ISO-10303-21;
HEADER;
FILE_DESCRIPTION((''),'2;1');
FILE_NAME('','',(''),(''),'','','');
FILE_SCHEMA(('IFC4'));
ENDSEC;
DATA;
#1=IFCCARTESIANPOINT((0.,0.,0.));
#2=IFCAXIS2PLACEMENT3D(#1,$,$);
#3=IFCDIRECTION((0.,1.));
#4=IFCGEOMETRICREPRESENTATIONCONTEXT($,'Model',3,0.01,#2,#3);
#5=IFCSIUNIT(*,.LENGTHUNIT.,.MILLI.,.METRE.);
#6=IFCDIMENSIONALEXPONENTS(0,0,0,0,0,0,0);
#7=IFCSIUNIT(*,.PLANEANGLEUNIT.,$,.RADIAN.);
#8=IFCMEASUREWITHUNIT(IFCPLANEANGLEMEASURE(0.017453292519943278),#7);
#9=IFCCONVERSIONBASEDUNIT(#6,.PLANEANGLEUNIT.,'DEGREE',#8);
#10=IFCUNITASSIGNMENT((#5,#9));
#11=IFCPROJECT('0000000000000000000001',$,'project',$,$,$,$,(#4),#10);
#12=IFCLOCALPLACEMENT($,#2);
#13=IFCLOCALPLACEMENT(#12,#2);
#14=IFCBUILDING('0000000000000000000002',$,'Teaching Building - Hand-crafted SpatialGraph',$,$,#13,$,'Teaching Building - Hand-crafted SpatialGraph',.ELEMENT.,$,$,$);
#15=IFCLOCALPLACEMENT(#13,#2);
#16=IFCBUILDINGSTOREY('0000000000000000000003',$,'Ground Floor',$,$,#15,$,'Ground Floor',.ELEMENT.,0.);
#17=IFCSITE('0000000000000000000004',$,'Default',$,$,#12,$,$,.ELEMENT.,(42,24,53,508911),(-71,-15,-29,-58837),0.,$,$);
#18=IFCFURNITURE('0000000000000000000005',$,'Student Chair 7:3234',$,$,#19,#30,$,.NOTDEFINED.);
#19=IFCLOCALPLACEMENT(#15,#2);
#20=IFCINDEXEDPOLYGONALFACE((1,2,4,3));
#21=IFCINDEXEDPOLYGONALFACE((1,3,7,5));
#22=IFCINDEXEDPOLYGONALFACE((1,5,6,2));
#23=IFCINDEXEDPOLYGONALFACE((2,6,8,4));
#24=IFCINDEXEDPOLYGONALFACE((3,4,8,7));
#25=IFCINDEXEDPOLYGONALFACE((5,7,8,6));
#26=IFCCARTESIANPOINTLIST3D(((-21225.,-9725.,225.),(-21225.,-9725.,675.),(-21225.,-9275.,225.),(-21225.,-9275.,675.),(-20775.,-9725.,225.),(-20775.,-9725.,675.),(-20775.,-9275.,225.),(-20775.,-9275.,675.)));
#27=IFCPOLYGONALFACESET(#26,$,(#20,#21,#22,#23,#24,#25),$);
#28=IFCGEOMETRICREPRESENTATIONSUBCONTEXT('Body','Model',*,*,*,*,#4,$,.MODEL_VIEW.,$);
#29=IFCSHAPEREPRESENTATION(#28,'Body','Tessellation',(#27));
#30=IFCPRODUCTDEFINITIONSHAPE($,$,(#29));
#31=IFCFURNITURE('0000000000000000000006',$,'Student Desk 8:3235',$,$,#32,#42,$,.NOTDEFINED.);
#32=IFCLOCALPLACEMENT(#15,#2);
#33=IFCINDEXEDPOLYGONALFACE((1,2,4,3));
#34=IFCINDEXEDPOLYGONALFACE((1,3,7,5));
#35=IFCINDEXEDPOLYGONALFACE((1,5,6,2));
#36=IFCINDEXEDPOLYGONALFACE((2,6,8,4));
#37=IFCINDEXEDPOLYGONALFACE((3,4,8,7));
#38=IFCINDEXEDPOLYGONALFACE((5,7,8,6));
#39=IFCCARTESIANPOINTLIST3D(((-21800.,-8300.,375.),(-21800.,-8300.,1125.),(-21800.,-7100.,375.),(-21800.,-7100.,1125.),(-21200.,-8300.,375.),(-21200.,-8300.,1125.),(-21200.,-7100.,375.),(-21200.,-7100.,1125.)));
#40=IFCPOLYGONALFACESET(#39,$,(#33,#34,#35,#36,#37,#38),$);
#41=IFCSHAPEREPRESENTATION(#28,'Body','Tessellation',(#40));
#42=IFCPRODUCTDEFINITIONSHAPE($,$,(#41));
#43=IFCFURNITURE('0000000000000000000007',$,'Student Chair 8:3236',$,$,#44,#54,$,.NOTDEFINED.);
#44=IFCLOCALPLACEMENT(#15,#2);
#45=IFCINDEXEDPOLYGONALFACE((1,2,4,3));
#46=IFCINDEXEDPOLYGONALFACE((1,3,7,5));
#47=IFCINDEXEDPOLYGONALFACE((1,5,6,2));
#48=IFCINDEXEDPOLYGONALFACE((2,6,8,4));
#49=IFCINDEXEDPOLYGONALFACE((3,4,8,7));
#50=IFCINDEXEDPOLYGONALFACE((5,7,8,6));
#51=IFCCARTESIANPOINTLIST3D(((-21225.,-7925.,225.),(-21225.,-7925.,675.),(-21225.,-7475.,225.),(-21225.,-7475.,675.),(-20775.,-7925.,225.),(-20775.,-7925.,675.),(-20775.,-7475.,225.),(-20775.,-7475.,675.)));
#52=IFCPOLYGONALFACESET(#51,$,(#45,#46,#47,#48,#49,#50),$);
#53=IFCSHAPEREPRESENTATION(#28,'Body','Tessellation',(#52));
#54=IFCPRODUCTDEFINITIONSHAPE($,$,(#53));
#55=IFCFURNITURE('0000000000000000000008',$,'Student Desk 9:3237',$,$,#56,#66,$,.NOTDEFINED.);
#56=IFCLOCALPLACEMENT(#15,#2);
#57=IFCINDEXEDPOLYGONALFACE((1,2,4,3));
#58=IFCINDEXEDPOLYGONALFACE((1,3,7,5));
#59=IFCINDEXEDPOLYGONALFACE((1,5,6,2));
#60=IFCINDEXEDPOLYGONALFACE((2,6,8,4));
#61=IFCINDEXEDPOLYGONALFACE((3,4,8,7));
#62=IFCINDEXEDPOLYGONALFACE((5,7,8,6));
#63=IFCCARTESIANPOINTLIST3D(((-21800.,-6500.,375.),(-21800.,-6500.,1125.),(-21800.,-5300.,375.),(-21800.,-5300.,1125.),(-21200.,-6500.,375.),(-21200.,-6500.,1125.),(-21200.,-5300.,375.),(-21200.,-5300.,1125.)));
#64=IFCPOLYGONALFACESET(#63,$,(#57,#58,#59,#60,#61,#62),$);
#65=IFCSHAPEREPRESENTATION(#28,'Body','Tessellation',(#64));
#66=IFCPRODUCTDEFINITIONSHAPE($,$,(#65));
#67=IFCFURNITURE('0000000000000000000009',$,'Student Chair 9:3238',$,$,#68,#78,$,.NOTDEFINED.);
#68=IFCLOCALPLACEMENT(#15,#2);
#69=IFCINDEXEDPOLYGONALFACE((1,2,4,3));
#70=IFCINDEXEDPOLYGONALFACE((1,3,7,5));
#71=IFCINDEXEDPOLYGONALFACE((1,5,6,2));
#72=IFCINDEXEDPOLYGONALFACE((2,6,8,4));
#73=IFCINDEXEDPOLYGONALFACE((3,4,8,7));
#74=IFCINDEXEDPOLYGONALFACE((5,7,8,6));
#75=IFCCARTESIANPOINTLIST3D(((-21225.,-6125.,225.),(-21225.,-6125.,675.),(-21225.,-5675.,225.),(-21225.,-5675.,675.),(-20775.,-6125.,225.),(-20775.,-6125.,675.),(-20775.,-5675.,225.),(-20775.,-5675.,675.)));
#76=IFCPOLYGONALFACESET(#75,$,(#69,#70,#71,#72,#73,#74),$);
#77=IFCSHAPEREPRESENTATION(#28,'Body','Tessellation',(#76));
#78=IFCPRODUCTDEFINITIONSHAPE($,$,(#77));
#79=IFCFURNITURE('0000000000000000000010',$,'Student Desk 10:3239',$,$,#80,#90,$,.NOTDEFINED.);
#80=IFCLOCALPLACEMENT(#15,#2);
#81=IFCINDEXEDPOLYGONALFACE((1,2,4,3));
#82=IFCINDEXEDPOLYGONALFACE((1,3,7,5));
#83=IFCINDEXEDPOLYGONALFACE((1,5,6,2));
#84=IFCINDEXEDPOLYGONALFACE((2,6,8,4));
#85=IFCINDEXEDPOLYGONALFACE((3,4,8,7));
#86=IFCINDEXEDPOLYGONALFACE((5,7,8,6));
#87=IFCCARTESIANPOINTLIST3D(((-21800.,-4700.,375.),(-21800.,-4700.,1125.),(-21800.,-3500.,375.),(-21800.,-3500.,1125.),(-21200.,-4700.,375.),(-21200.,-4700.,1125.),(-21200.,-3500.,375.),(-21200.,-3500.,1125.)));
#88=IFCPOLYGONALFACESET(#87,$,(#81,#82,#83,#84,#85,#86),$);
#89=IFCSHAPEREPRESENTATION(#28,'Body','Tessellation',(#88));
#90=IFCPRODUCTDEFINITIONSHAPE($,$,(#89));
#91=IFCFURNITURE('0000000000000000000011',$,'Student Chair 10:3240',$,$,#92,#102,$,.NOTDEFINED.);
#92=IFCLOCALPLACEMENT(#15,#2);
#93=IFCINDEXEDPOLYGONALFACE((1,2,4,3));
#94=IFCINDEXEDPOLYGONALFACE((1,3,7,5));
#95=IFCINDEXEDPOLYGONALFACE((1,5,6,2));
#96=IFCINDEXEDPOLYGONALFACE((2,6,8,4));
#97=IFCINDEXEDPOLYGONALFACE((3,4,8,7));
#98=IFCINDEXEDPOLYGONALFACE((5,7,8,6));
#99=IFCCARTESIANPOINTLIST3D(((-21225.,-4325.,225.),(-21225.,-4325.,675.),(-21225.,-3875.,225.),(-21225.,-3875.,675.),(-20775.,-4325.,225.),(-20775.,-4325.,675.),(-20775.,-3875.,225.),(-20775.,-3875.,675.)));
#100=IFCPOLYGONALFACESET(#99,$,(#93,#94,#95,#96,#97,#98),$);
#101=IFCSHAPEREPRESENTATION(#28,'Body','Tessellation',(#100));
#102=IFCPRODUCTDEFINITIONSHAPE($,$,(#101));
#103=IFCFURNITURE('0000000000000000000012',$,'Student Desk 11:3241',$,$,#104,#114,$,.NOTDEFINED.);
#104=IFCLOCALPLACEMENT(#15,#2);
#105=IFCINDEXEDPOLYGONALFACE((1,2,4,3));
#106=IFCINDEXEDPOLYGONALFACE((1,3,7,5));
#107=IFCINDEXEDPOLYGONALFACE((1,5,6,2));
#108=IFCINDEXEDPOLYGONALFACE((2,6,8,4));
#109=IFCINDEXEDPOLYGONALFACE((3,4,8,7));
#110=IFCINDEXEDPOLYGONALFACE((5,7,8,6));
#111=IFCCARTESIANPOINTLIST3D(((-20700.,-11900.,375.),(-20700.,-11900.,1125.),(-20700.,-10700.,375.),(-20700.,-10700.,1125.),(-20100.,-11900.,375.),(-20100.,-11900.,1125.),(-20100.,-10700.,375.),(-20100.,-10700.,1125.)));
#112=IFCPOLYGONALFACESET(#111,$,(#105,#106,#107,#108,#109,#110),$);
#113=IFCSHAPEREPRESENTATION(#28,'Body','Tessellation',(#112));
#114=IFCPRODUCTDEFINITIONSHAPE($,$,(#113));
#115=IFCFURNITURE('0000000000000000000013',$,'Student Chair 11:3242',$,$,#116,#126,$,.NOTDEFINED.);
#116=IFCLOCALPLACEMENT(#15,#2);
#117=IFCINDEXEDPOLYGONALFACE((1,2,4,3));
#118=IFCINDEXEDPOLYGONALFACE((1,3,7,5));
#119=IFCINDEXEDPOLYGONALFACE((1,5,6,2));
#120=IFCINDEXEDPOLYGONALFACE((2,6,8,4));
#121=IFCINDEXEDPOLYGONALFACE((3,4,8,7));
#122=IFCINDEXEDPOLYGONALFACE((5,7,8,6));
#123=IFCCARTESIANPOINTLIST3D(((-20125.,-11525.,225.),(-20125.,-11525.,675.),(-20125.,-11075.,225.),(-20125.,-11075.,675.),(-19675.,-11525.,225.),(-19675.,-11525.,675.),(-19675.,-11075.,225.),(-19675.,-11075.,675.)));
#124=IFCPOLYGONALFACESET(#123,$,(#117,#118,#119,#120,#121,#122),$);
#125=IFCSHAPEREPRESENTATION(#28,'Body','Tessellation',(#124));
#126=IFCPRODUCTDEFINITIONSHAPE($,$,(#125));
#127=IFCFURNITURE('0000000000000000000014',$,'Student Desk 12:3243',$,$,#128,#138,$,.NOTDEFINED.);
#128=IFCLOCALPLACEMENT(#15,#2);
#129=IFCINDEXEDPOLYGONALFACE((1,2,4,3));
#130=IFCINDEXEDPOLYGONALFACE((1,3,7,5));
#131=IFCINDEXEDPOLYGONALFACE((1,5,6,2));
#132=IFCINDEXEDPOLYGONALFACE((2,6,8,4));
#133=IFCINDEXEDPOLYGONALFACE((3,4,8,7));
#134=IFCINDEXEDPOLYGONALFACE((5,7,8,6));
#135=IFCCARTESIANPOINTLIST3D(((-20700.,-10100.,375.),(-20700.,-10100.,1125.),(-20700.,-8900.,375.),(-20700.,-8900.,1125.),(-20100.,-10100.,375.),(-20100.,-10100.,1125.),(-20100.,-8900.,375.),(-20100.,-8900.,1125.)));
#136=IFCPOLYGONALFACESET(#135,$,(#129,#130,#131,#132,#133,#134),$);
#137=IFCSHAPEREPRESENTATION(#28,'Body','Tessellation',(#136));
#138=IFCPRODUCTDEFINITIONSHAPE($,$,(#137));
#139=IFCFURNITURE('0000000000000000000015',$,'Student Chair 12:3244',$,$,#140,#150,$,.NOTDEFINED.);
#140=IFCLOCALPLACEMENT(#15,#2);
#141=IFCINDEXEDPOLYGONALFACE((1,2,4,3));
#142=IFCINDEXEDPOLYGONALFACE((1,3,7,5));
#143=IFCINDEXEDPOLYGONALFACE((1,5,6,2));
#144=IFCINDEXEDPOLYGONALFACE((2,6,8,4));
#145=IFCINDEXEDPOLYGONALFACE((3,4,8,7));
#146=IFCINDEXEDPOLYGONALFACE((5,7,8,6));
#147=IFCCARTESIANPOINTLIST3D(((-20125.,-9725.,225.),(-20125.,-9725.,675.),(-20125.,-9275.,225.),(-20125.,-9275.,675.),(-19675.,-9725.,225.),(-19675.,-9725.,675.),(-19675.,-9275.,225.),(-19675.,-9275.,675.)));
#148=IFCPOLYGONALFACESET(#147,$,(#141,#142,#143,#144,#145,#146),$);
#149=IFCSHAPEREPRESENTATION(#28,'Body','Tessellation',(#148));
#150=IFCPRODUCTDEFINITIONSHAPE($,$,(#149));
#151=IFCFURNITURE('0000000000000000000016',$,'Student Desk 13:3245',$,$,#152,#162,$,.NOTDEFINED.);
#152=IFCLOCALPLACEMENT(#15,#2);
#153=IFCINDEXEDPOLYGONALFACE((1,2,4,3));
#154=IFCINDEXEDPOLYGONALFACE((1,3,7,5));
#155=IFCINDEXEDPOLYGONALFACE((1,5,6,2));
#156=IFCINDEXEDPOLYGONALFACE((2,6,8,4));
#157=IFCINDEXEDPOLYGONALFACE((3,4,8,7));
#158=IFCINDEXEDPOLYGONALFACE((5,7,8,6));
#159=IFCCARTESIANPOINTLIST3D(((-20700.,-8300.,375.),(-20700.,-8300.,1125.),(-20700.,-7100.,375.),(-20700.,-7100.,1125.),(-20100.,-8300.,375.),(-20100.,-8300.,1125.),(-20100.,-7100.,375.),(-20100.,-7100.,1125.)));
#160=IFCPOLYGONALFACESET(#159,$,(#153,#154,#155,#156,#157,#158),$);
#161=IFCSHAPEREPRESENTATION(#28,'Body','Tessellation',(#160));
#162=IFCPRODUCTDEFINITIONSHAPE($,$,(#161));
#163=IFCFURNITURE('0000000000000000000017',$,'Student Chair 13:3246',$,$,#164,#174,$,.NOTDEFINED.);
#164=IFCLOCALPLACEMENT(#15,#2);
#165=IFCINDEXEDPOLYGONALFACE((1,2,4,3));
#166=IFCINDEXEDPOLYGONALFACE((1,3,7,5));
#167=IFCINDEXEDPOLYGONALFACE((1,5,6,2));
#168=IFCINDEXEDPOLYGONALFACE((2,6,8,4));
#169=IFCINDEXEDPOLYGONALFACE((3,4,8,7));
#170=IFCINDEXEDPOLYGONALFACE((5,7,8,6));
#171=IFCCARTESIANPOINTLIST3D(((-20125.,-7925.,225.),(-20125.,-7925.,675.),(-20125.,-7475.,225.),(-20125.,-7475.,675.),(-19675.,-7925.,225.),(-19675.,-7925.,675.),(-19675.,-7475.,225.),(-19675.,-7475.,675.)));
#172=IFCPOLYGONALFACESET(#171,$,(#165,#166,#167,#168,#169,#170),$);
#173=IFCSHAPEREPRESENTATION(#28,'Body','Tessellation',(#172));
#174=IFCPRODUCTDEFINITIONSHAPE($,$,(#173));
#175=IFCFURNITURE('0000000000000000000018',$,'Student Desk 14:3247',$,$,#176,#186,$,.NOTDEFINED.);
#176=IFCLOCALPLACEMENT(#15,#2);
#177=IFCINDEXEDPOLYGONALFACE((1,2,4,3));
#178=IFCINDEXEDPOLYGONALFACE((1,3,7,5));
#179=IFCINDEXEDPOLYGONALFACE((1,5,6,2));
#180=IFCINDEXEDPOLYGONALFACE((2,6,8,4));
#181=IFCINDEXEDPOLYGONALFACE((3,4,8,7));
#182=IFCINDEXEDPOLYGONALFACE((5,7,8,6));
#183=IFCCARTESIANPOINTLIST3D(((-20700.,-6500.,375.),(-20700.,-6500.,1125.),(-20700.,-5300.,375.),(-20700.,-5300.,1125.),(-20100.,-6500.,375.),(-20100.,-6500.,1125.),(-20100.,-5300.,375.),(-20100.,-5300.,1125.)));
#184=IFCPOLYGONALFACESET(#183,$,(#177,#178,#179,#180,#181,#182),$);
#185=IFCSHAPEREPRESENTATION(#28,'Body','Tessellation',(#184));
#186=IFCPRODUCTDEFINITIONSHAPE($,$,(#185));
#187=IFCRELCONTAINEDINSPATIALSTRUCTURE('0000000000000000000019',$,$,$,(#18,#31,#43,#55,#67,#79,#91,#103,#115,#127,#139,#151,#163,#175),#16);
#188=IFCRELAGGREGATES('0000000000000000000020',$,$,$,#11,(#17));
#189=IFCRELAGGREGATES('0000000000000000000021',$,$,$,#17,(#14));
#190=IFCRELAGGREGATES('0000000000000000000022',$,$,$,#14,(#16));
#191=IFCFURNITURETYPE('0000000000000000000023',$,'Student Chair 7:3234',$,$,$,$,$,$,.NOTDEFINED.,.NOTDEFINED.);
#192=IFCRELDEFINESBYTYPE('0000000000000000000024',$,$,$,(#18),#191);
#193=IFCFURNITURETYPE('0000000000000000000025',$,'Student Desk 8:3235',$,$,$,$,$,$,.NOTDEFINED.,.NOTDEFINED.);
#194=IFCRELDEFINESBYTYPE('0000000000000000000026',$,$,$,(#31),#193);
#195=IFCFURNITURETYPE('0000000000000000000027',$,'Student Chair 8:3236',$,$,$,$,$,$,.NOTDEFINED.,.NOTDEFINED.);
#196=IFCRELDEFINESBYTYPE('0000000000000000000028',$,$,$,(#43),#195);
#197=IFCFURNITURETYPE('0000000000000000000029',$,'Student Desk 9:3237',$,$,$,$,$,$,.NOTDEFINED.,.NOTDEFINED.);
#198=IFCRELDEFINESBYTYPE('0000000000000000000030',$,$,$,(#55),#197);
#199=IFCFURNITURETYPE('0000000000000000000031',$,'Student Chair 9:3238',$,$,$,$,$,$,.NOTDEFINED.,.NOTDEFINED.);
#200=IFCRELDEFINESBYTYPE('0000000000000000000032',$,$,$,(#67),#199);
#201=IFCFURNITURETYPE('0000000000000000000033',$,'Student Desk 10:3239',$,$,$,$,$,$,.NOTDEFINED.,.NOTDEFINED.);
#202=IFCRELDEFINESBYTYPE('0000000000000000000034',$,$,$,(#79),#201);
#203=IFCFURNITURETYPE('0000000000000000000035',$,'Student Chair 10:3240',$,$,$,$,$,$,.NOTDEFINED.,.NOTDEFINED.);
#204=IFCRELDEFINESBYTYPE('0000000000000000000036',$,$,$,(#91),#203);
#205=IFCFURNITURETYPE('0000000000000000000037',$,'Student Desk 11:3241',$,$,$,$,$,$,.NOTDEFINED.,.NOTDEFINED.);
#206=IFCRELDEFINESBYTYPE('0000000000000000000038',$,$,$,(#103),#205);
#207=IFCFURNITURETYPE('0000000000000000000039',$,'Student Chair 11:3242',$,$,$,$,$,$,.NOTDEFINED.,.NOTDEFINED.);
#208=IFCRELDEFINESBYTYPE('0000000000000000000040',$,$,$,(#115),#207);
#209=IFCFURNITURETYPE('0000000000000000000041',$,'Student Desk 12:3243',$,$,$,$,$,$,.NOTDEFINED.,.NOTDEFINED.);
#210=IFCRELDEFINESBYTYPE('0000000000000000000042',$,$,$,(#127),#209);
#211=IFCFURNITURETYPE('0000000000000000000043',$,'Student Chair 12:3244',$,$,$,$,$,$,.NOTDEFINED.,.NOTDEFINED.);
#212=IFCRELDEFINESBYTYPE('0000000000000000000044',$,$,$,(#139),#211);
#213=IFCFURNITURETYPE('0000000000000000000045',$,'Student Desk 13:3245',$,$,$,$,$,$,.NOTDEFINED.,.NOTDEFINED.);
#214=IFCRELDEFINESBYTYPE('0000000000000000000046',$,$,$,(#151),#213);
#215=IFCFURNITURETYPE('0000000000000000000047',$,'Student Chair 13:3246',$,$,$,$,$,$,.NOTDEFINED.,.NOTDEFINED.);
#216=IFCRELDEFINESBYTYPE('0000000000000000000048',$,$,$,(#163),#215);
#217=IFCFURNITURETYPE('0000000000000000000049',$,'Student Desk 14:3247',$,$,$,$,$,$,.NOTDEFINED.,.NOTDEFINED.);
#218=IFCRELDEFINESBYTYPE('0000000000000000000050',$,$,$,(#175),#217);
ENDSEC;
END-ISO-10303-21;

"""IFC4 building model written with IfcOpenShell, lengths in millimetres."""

from ifc_helpers import new_model, entity, si_unit, converted_unit, direction, frame, frame_2d, origin, origin_2d_with_axis, place, context, subcontext, project, spatial, rectangle, extrude, type_object, element, save


model = new_model("IFC4")

# Units and contexts
model_context = context("Model", 3, precision=0.01, world=origin(), true_north=direction((0.0, 1.0)))
body_context = subcontext(model_context, "Body", "Model", "MODEL_VIEW")
ifc_project = project(units=[si_unit("LENGTHUNIT", "METRE", prefix="MILLI"), converted_unit("PLANEANGLEUNIT", "DEGREE", entity("IfcPlaneAngleMeasure", 0.017453292519943278), si_unit("PLANEANGLEUNIT", "RADIAN"), dimensions=[0, 0, 0, 0, 0, 0, 0])], contexts=[model_context])

# Site, building, storey
site_placement = place(None, origin())
site = spatial("IfcSite", under=ifc_project, at=site_placement, Name="Default", CompositionType="ELEMENT", RefLatitude=(42, 24, 53, 508911), RefLongitude=(-71, -15, -29, -58837), RefElevation=0.0)
building_placement = place(site_placement, origin())
building = spatial("IfcBuilding", under=site, at=building_placement, Name="Teaching Building - Hand-crafted SpatialGraph", LongName="Teaching Building - Hand-crafted SpatialGraph", CompositionType="ELEMENT")
storey_placement = place(building_placement, origin())
storey = spatial("IfcBuildingStorey", under=building, at=storey_placement, Name="Ground Floor", LongName="Ground Floor", CompositionType="ELEMENT", Elevation=0.0)

# Furniture
furniture_type_1 = type_object("IfcFurnitureType", Name="Student Chair 7:3234", PredefinedType="NOTDEFINED")
furniture_1_placement = place(storey_placement, origin())
element("IfcFurniture", 1, at=furniture_1_placement, inside=storey, type_object=furniture_type_1, Name="Student Chair 7:3234", PredefinedType="NOTDEFINED", context=body_context, shape_type="SweptSolid", body=[
    extrude(rectangle(XDim=450.0, YDim=450.0, at=origin_2d_with_axis()), frame((-21000.0, -9500.0, 225.0)), (0.0, 0.0, 1.0), 450.0),
])
furniture_type_2 = type_object("IfcFurnitureType", Name="Student Desk 8:3235", PredefinedType="NOTDEFINED")
furniture_2_placement = place(storey_placement, origin())
element("IfcFurniture", 2, at=furniture_2_placement, inside=storey, type_object=furniture_type_2, Name="Student Desk 8:3235", PredefinedType="NOTDEFINED", context=body_context, shape_type="SweptSolid", body=[
    extrude(rectangle(XDim=1200.0, YDim=600.0, at=origin_2d_with_axis()), frame((-21500.0, -7700.0, 375.0), z_axis=(0.0, 0.0, 1.0), x_axis=(0.0, 1.0, 0.0)), (0.0, 0.0, 1.0), 750.0),
])
furniture_type_3 = type_object("IfcFurnitureType", Name="Student Chair 8:3236", PredefinedType="NOTDEFINED")
furniture_3_placement = place(storey_placement, origin())
element("IfcFurniture", 3, at=furniture_3_placement, inside=storey, type_object=furniture_type_3, Name="Student Chair 8:3236", PredefinedType="NOTDEFINED", context=body_context, shape_type="SweptSolid", body=[
    extrude(rectangle(XDim=450.0, YDim=450.0, at=frame_2d((0.0, 0.0), x_axis=(1.0, 0.0))), frame((-21000.0, -7700.0, 225.0)), (0.0, 0.0, 1.0), 450.0),
])
furniture_type_4 = type_object("IfcFurnitureType", Name="Student Desk 9:3237", PredefinedType="NOTDEFINED")
furniture_4_placement = place(storey_placement, origin())
element("IfcFurniture", 4, at=furniture_4_placement, inside=storey, type_object=furniture_type_4, Name="Student Desk 9:3237", PredefinedType="NOTDEFINED", context=body_context, shape_type="SweptSolid", body=[
    extrude(rectangle(XDim=1200.0, YDim=600.0, at=origin_2d_with_axis()), frame((-21500.0, -5900.0, 375.0), z_axis=(0.0, 0.0, 1.0), x_axis=(0.0, 1.0, 0.0)), (0.0, 0.0, 1.0), 750.0),
])
furniture_type_5 = type_object("IfcFurnitureType", Name="Student Chair 9:3238", PredefinedType="NOTDEFINED")
furniture_5_placement = place(storey_placement, origin())
element("IfcFurniture", 5, at=furniture_5_placement, inside=storey, type_object=furniture_type_5, Name="Student Chair 9:3238", PredefinedType="NOTDEFINED", context=body_context, shape_type="SweptSolid", body=[
    extrude(rectangle(XDim=450.0, YDim=450.0, at=origin_2d_with_axis()), frame((-21000.0, -5900.0, 225.0)), (0.0, 0.0, 1.0), 450.0),
])
furniture_type_6 = type_object("IfcFurnitureType", Name="Student Desk 10:3239", PredefinedType="NOTDEFINED")
furniture_6_placement = place(storey_placement, origin())
element("IfcFurniture", 6, at=furniture_6_placement, inside=storey, type_object=furniture_type_6, Name="Student Desk 10:3239", PredefinedType="NOTDEFINED", context=body_context, shape_type="SweptSolid", body=[
    extrude(rectangle(XDim=1200.0, YDim=600.0, at=origin_2d_with_axis()), frame((-21500.0, -4100.0, 375.0), z_axis=(0.0, 0.0, 1.0), x_axis=(0.0, 1.0, 0.0)), (0.0, 0.0, 1.0), 750.0),
])
furniture_type_7 = type_object("IfcFurnitureType", Name="Student Chair 10:3240", PredefinedType="NOTDEFINED")
furniture_7_placement = place(storey_placement, origin())
element("IfcFurniture", 7, at=furniture_7_placement, inside=storey, type_object=furniture_type_7, Name="Student Chair 10:3240", PredefinedType="NOTDEFINED", context=body_context, shape_type="SweptSolid", body=[
    extrude(rectangle(XDim=450.0, YDim=450.0, at=origin_2d_with_axis()), frame((-21000.0, -4100.0, 225.0)), (0.0, 0.0, 1.0), 450.0),
])
furniture_type_8 = type_object("IfcFurnitureType", Name="Student Desk 11:3241", PredefinedType="NOTDEFINED")
furniture_8_placement = place(storey_placement, origin())
element("IfcFurniture", 8, at=furniture_8_placement, inside=storey, type_object=furniture_type_8, Name="Student Desk 11:3241", PredefinedType="NOTDEFINED", context=body_context, shape_type="SweptSolid", body=[
    extrude(rectangle(XDim=1200.0, YDim=600.0, at=origin_2d_with_axis()), frame((-20400.0, -11300.0, 375.0), z_axis=(0.0, 0.0, 1.0), x_axis=(0.0, 1.0, 0.0)), (0.0, 0.0, 1.0), 750.0),
])
furniture_type_9 = type_object("IfcFurnitureType", Name="Student Chair 11:3242", PredefinedType="NOTDEFINED")
furniture_9_placement = place(storey_placement, origin())
element("IfcFurniture", 9, at=furniture_9_placement, inside=storey, type_object=furniture_type_9, Name="Student Chair 11:3242", PredefinedType="NOTDEFINED", context=body_context, shape_type="SweptSolid", body=[
    extrude(rectangle(XDim=450.0, YDim=450.0, at=origin_2d_with_axis()), frame((-19900.0, -11300.0, 225.0)), (0.0, 0.0, 1.0), 450.0),
])
furniture_type_10 = type_object("IfcFurnitureType", Name="Student Desk 12:3243", PredefinedType="NOTDEFINED")
furniture_10_placement = place(storey_placement, origin())
element("IfcFurniture", 10, at=furniture_10_placement, inside=storey, type_object=furniture_type_10, Name="Student Desk 12:3243", PredefinedType="NOTDEFINED", context=body_context, shape_type="SweptSolid", body=[
    extrude(rectangle(XDim=1200.0, YDim=600.0, at=origin_2d_with_axis()), frame((-20400.0, -9500.0, 375.0), z_axis=(0.0, 0.0, 1.0), x_axis=(0.0, 1.0, 0.0)), (0.0, 0.0, 1.0), 750.0),
])
furniture_type_11 = type_object("IfcFurnitureType", Name="Student Chair 12:3244", PredefinedType="NOTDEFINED")
furniture_11_placement = place(storey_placement, origin())
element("IfcFurniture", 11, at=furniture_11_placement, inside=storey, type_object=furniture_type_11, Name="Student Chair 12:3244", PredefinedType="NOTDEFINED", context=body_context, shape_type="SweptSolid", body=[
    extrude(rectangle(XDim=450.0, YDim=450.0, at=origin_2d_with_axis()), frame((-19900.0, -9500.0, 225.0)), (0.0, 0.0, 1.0), 450.0),
])
furniture_type_12 = type_object("IfcFurnitureType", Name="Student Desk 13:3245", PredefinedType="NOTDEFINED")
furniture_12_placement = place(storey_placement, origin())
element("IfcFurniture", 12, at=furniture_12_placement, inside=storey, type_object=furniture_type_12, Name="Student Desk 13:3245", PredefinedType="NOTDEFINED", context=body_context, shape_type="SweptSolid", body=[
    extrude(rectangle(XDim=1200.0, YDim=600.0, at=origin_2d_with_axis()), frame((-20400.0, -7700.0, 375.0), z_axis=(0.0, 0.0, 1.0), x_axis=(0.0, 1.0, 0.0)), (0.0, 0.0, 1.0), 750.0),
])
furniture_type_13 = type_object("IfcFurnitureType", Name="Student Chair 13:3246", PredefinedType="NOTDEFINED")
furniture_13_placement = place(storey_placement, origin())
element("IfcFurniture", 13, at=furniture_13_placement, inside=storey, type_object=furniture_type_13, Name="Student Chair 13:3246", PredefinedType="NOTDEFINED", context=body_context, shape_type="SweptSolid", body=[
    extrude(rectangle(XDim=450.0, YDim=450.0, at=frame_2d((0.0, 0.0), x_axis=(1.0, 0.0))), frame((-19900.0, -7700.0, 225.0)), (0.0, 0.0, 1.0), 450.0),
])
furniture_type_14 = type_object("IfcFurnitureType", Name="Student Desk 14:3247", PredefinedType="NOTDEFINED")
furniture_14_placement = place(storey_placement, origin())
element("IfcFurniture", 14, at=furniture_14_placement, inside=storey, type_object=furniture_type_14, Name="Student Desk 14:3247", PredefinedType="NOTDEFINED", context=body_context, shape_type="SweptSolid", body=[
    extrude(rectangle(XDim=1200.0, YDim=600.0, at=origin_2d_with_axis()), frame((-20400.0, -5900.0, 375.0), z_axis=(0.0, 0.0, 1.0), x_axis=(0.0, 1.0, 0.0)), (0.0, 0.0, 1.0), 750.0),
])

save(model, "model.ifc")
